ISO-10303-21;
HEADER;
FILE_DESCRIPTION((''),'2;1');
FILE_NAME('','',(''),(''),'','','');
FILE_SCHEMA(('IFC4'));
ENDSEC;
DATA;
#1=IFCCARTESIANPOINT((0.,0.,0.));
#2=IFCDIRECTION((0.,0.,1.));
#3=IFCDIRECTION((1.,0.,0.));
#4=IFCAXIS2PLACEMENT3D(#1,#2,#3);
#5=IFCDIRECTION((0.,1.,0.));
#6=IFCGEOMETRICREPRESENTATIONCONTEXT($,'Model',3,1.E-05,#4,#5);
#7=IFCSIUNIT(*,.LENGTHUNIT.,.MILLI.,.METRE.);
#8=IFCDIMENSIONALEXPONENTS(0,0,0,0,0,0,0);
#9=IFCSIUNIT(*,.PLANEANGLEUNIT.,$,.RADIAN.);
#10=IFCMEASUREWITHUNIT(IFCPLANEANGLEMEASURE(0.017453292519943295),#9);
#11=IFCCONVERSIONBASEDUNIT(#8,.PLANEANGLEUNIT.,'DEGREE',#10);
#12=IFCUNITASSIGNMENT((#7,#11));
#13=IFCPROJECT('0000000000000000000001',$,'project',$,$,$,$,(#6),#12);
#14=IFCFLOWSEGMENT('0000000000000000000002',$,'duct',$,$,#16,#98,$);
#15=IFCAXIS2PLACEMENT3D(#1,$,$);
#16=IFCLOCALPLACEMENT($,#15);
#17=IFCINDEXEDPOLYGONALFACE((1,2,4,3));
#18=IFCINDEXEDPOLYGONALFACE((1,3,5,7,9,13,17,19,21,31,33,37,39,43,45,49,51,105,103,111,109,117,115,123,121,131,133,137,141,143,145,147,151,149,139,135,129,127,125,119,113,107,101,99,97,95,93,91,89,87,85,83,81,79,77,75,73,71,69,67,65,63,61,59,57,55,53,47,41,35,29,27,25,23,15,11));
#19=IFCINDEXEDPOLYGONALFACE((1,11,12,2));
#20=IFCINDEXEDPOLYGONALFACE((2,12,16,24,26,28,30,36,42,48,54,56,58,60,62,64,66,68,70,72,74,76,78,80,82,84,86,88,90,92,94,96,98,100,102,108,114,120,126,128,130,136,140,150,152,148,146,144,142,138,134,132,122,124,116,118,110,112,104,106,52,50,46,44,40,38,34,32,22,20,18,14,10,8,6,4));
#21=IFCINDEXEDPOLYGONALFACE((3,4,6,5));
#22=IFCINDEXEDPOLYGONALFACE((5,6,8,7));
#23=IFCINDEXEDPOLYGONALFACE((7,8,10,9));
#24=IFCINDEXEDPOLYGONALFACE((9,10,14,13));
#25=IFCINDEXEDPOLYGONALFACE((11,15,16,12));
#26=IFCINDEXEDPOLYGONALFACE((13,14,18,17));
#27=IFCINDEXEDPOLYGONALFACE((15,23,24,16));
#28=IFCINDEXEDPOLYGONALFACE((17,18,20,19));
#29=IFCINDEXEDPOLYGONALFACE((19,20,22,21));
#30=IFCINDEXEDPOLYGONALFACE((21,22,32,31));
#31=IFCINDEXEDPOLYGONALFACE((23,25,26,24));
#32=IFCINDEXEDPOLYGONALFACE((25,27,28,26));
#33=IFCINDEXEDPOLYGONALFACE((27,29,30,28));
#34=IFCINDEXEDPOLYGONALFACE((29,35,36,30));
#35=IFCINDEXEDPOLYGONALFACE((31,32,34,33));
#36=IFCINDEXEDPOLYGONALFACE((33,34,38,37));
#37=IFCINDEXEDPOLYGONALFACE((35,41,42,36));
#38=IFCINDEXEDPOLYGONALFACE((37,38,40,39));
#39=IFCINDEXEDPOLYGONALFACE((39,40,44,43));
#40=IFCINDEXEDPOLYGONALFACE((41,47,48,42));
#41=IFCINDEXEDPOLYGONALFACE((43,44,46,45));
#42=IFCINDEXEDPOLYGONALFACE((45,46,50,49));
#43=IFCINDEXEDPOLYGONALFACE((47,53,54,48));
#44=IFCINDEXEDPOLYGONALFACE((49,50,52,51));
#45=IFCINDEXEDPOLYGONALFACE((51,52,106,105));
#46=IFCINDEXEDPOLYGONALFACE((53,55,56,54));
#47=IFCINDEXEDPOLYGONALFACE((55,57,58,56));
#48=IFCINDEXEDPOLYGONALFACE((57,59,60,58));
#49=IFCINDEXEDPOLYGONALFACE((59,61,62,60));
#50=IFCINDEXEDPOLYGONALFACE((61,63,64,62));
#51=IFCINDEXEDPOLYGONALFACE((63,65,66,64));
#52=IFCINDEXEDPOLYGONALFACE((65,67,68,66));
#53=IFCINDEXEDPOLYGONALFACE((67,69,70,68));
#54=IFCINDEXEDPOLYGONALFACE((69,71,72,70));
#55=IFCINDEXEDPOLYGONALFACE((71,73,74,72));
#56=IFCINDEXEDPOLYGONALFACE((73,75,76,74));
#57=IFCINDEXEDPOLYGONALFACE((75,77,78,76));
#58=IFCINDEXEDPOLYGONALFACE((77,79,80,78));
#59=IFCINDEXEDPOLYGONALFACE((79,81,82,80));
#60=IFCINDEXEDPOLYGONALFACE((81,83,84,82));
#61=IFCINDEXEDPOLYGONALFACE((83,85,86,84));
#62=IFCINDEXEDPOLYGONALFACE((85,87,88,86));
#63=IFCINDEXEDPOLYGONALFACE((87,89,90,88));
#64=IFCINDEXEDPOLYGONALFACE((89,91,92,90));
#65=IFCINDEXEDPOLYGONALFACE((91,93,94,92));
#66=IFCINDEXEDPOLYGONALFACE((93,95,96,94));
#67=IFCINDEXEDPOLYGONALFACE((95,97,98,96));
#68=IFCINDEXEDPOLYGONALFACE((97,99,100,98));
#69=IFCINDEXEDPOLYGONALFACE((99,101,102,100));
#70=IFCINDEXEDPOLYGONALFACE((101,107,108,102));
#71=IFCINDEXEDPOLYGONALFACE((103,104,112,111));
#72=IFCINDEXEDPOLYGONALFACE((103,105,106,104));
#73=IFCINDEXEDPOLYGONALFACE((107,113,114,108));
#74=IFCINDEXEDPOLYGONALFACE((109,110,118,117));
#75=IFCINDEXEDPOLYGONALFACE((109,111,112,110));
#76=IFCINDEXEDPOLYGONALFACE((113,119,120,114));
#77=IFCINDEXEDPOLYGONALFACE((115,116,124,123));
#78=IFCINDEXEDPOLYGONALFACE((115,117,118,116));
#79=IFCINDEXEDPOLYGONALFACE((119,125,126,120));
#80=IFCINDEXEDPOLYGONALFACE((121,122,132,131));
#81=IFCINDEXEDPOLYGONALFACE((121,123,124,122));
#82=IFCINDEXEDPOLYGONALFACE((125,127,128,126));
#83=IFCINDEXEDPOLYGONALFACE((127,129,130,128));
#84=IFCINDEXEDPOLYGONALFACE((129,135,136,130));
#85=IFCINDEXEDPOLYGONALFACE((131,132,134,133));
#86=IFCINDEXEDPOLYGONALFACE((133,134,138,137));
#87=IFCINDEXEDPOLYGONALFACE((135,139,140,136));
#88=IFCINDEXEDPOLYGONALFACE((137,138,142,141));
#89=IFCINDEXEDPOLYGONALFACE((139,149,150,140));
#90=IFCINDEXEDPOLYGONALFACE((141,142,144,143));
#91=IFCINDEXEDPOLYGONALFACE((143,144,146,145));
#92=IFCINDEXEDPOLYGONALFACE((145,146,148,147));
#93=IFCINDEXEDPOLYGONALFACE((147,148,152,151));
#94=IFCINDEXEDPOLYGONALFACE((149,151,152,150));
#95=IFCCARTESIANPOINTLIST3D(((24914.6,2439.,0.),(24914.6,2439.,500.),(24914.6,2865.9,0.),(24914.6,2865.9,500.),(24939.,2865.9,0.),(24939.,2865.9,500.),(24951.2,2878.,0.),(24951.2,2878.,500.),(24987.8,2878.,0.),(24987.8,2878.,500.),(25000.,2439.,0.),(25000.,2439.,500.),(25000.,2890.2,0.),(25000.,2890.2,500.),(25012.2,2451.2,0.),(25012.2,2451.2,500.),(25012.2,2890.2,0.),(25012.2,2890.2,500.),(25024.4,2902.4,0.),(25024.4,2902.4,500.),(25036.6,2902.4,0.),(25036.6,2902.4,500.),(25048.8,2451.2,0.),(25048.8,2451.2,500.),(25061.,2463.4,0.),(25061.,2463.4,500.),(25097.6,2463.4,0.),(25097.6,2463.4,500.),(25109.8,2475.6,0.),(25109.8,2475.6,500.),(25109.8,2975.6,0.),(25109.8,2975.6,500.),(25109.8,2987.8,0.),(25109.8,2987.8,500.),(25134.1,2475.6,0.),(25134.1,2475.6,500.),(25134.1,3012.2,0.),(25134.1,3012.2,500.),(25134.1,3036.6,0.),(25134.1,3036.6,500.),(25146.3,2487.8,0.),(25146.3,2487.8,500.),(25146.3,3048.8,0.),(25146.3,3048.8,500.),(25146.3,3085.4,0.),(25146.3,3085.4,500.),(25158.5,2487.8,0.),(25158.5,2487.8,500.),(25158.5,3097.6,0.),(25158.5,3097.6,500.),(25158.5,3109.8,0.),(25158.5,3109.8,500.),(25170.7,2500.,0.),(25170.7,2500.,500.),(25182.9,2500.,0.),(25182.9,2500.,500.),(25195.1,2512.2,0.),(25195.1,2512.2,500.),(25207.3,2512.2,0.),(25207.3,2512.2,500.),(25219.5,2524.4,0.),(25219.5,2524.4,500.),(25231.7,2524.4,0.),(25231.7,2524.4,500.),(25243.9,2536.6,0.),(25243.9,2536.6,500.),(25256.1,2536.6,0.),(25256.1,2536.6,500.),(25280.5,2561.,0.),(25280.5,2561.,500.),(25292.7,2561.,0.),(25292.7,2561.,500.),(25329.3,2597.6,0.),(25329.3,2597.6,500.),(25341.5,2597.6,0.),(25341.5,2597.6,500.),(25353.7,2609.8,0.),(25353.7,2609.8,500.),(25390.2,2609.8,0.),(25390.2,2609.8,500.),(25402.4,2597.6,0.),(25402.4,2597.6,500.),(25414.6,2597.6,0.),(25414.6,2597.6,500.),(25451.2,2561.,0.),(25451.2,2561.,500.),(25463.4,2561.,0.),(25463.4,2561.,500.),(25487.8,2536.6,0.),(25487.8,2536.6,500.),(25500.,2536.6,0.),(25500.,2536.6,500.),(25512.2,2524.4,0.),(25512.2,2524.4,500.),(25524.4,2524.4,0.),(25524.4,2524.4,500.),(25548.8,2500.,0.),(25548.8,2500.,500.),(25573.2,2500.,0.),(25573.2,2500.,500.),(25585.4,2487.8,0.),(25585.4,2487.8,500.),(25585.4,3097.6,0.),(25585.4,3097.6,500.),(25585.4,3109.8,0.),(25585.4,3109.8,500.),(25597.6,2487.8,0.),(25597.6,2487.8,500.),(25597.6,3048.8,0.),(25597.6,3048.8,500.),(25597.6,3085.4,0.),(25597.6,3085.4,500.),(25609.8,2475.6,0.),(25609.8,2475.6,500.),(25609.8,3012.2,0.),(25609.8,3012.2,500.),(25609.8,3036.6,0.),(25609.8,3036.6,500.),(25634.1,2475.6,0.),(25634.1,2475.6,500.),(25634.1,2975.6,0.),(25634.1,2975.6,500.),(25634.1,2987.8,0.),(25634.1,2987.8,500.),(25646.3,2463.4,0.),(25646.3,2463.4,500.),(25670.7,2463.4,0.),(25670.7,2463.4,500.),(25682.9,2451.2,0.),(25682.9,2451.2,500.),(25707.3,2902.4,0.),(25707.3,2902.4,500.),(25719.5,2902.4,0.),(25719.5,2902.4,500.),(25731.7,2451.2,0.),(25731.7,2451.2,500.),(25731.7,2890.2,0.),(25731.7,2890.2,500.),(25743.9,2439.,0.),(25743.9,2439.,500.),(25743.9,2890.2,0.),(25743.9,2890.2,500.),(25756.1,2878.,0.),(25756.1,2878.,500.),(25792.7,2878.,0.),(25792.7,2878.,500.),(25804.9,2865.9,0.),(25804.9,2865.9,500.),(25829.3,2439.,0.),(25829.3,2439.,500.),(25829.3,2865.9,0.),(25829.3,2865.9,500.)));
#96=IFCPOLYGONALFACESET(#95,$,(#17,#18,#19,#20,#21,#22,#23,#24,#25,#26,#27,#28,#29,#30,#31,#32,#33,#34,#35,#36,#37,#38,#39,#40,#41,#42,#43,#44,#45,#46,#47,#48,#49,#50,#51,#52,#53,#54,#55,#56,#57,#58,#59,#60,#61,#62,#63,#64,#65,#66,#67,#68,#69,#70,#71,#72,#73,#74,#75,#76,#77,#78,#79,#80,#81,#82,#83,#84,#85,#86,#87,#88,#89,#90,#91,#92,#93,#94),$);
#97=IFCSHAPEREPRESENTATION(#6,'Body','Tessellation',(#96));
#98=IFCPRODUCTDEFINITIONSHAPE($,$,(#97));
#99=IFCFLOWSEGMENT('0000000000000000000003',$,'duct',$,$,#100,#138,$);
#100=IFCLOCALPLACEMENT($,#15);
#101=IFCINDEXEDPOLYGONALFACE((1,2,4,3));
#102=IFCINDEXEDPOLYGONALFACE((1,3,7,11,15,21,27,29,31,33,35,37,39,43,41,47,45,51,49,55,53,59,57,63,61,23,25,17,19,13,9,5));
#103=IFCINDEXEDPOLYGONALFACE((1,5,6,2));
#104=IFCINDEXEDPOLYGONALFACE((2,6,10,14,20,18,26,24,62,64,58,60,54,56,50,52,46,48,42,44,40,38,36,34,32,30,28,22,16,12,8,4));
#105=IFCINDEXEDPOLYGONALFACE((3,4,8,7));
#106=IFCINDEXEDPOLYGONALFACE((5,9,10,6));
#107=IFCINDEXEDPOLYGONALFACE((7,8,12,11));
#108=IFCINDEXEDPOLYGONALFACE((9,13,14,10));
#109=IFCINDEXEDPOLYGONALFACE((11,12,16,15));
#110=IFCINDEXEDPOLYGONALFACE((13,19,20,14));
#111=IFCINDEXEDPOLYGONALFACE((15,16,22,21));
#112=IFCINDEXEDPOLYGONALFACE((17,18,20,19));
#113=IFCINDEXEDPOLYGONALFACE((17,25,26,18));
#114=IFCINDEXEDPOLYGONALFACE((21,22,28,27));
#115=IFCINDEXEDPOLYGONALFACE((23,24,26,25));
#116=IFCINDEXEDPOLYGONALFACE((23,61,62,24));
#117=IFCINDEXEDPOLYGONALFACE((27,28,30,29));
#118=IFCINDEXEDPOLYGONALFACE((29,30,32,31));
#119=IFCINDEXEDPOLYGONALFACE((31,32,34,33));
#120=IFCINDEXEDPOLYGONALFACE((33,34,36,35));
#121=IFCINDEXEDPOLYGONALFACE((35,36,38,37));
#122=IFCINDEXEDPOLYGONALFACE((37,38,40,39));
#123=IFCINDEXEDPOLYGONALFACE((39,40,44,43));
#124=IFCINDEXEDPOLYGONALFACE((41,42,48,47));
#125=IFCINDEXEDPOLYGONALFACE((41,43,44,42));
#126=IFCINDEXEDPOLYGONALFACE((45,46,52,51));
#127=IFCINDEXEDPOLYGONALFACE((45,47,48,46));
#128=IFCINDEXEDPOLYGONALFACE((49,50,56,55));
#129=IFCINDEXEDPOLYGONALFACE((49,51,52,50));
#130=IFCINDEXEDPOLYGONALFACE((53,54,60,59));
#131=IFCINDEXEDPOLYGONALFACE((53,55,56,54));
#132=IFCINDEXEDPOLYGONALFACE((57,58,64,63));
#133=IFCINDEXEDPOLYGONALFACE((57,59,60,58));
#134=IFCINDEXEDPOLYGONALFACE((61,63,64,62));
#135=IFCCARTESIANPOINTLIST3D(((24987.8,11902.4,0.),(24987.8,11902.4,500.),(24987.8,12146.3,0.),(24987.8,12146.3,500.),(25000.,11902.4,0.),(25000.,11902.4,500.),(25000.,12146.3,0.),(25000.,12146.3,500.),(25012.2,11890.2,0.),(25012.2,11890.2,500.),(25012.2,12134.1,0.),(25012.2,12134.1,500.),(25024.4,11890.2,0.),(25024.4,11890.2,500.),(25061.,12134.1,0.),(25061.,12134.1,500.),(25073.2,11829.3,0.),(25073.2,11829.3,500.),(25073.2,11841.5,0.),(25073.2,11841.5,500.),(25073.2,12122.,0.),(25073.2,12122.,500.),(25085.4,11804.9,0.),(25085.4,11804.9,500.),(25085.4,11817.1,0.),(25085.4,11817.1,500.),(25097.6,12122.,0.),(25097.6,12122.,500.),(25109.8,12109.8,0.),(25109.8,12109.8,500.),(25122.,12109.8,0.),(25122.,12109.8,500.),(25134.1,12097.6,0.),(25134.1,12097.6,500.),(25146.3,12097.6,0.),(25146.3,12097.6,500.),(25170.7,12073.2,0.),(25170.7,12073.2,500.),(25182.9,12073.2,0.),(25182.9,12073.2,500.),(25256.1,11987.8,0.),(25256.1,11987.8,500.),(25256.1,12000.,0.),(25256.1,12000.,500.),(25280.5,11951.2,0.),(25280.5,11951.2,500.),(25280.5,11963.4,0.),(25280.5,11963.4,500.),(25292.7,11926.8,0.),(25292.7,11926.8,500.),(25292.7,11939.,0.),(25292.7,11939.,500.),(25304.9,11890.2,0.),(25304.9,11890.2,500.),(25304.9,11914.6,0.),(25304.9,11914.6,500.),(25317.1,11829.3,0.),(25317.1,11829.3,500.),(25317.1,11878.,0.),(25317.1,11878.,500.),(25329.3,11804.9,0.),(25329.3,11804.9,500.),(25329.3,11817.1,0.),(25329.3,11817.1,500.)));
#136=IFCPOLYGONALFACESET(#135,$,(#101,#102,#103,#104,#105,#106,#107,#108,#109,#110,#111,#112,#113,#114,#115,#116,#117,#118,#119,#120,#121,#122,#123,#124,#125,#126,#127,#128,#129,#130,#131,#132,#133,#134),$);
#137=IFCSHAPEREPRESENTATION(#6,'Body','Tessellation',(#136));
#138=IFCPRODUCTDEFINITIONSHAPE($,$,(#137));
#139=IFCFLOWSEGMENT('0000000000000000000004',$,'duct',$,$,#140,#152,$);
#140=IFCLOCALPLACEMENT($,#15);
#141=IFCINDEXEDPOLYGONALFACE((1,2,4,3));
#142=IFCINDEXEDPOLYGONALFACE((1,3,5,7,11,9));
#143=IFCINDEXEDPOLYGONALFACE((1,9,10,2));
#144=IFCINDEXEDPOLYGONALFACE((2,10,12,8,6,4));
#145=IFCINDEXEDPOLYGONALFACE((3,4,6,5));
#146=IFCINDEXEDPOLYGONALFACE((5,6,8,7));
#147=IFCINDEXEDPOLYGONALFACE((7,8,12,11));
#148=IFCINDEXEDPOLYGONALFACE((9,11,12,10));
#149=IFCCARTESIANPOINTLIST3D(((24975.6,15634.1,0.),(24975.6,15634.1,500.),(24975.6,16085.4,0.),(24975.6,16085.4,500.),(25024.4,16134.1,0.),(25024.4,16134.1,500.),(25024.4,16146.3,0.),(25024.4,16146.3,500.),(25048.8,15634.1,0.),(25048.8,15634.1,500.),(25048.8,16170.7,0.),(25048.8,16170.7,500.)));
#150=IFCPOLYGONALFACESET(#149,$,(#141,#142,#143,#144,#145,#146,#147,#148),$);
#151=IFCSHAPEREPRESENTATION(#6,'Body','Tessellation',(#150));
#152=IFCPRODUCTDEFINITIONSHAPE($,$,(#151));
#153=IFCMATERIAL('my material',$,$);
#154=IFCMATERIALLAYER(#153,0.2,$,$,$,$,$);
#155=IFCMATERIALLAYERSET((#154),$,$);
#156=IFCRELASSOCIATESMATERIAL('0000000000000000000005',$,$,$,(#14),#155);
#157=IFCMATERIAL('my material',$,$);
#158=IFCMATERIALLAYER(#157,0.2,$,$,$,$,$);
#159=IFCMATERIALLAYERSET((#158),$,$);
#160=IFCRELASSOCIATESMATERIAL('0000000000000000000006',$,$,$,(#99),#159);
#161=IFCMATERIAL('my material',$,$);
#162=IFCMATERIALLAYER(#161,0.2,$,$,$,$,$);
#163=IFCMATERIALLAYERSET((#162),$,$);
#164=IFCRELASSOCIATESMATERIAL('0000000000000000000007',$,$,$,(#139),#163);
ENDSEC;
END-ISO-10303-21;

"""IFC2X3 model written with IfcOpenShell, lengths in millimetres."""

from ifc_helpers import new_model, entity, si_unit, converted_unit, direction, origin_with_axes, place, context, project, polyline, outline, extrude, material, layer, layer_set, layer_usage, element, save


model = new_model("IFC2X3")

# Units and contexts
model_context = context("Model", 3, precision=1e-05, world=origin_with_axes(), true_north=direction((0.0, 1.0, 0.0)))
ifc_project = project(units=[si_unit("LENGTHUNIT", "METRE", prefix="MILLI"), converted_unit("PLANEANGLEUNIT", "DEGREE", entity("IfcPlaneAngleMeasure", 0.017453292519943295), si_unit("PLANEANGLEUNIT", "RADIAN"), dimensions=[0, 0, 0, 0, 0, 0, 0])], contexts=[model_context])

# Flow segments
ifc_material_1 = material(Name="my material")
ifc_layer_1 = layer(ifc_material_1, 0.2)
ifc_layer_set_1 = layer_set([ifc_layer_1])
ifc_layer_usage_1 = layer_usage(ifc_layer_set_1, "AXIS2", "POSITIVE", -0.1)
flow_segment_1_placement = place(None, origin_with_axes())
element("IfcFlowSegment", 1, at=flow_segment_1_placement, material=ifc_layer_usage_1, Name="duct", context=model_context, shape_type="SweptSolid", body=[
    extrude(outline(polyline([(24914.6, 2439.0), (25000.0, 2439.0), (25012.2, 2451.2), (25048.8, 2451.2), (25061.0, 2463.4), (25097.6, 2463.4), (25109.8, 2475.6), (25134.1, 2475.6), (25146.3, 2487.8), (25158.5, 2487.8), (25170.7, 2500.0), (25182.9, 2500.0), (25195.1, 2512.2), (25207.3, 2512.2), (25219.5, 2524.4), (25231.7, 2524.4), (25243.9, 2536.6), (25256.1, 2536.6), (25280.5, 2561.0), (25292.7, 2561.0), (25329.3, 2597.6), (25341.5, 2597.6), (25353.7, 2609.8), (25390.2, 2609.8), (25402.4, 2597.6), (25414.6, 2597.6), (25451.2, 2561.0), (25463.4, 2561.0), (25487.8, 2536.6), (25500.0, 2536.6), (25512.2, 2524.4), (25524.4, 2524.4), (25548.8, 2500.0), (25573.2, 2500.0), (25585.4, 2487.8), (25597.6, 2487.8), (25609.8, 2475.6), (25634.1, 2475.6), (25646.3, 2463.4), (25670.7, 2463.4), (25682.9, 2451.2), (25731.7, 2451.2), (25743.9, 2439.0), (25829.3, 2439.0), (25829.3, 2865.9), (25804.9, 2865.9), (25792.7, 2878.0), (25756.1, 2878.0), (25743.9, 2890.2), (25731.7, 2890.2), (25719.5, 2902.4), (25707.3, 2902.4), (25634.1, 2975.6), (25634.1, 2987.8), (25609.8, 3012.2), (25609.8, 3036.6), (25597.6, 3048.8), (25597.6, 3085.4), (25585.4, 3097.6), (25585.4, 3109.8), (25158.5, 3109.8), (25158.5, 3097.6), (25146.3, 3085.4), (25146.3, 3048.8), (25134.1, 3036.6), (25134.1, 3012.2), (25109.8, 2987.8), (25109.8, 2975.6), (25036.6, 2902.4), (25024.4, 2902.4), (25012.2, 2890.2), (25000.0, 2890.2), (24987.8, 2878.0), (24951.2, 2878.0), (24939.0, 2865.9), (24914.6, 2865.9), (24914.6, 2439.0)])), origin_with_axes(), (0.0, 0.0, 1.0), 500.0),
])
ifc_material_2 = material(Name="my material")
ifc_layer_2 = layer(ifc_material_2, 0.2)
ifc_layer_set_2 = layer_set([ifc_layer_2])
ifc_layer_usage_2 = layer_usage(ifc_layer_set_2, "AXIS2", "POSITIVE", -0.1)
flow_segment_2_placement = place(None, origin_with_axes())
element("IfcFlowSegment", 2, at=flow_segment_2_placement, material=ifc_layer_usage_2, Name="duct", context=model_context, shape_type="SweptSolid", body=[
    extrude(outline(polyline([(24987.8, 11902.4), (25000.0, 11902.4), (25012.2, 11890.2), (25024.4, 11890.2), (25073.2, 11841.5), (25073.2, 11829.3), (25085.4, 11817.1), (25085.4, 11804.9), (25329.3, 11804.9), (25329.3, 11817.1), (25317.1, 11829.3), (25317.1, 11878.0), (25304.9, 11890.2), (25304.9, 11914.6), (25292.7, 11926.8), (25292.7, 11939.0), (25280.5, 11951.2), (25280.5, 11963.4), (25256.1, 11987.8), (25256.1, 12000.0), (25182.9, 12073.2), (25170.7, 12073.2), (25146.3, 12097.6), (25134.1, 12097.6), (25122.0, 12109.8), (25109.8, 12109.8), (25097.6, 12122.0), (25073.2, 12122.0), (25061.0, 12134.1), (25012.2, 12134.1), (25000.0, 12146.3), (24987.8, 12146.3), (24987.8, 11902.4)])), origin_with_axes(), (0.0, 0.0, 1.0), 500.0),
])
ifc_material_3 = material(Name="my material")
ifc_layer_3 = layer(ifc_material_3, 0.2)
ifc_layer_set_3 = layer_set([ifc_layer_3])
ifc_layer_usage_3 = layer_usage(ifc_layer_set_3, "AXIS2", "POSITIVE", -0.1)
flow_segment_3_placement = place(None, origin_with_axes())
element("IfcFlowSegment", 3, at=flow_segment_3_placement, material=ifc_layer_usage_3, Name="duct", context=model_context, shape_type="SweptSolid", body=[
    extrude(outline(polyline([(24975.6, 15634.1), (25048.8, 15634.1), (25048.8, 16170.7), (25024.4, 16146.3), (25024.4, 16134.1), (24975.6, 16085.4), (24975.6, 15634.1)])), origin_with_axes(), (0.0, 0.0, 1.0), 500.0),
])

save(model, "model.ifc")
